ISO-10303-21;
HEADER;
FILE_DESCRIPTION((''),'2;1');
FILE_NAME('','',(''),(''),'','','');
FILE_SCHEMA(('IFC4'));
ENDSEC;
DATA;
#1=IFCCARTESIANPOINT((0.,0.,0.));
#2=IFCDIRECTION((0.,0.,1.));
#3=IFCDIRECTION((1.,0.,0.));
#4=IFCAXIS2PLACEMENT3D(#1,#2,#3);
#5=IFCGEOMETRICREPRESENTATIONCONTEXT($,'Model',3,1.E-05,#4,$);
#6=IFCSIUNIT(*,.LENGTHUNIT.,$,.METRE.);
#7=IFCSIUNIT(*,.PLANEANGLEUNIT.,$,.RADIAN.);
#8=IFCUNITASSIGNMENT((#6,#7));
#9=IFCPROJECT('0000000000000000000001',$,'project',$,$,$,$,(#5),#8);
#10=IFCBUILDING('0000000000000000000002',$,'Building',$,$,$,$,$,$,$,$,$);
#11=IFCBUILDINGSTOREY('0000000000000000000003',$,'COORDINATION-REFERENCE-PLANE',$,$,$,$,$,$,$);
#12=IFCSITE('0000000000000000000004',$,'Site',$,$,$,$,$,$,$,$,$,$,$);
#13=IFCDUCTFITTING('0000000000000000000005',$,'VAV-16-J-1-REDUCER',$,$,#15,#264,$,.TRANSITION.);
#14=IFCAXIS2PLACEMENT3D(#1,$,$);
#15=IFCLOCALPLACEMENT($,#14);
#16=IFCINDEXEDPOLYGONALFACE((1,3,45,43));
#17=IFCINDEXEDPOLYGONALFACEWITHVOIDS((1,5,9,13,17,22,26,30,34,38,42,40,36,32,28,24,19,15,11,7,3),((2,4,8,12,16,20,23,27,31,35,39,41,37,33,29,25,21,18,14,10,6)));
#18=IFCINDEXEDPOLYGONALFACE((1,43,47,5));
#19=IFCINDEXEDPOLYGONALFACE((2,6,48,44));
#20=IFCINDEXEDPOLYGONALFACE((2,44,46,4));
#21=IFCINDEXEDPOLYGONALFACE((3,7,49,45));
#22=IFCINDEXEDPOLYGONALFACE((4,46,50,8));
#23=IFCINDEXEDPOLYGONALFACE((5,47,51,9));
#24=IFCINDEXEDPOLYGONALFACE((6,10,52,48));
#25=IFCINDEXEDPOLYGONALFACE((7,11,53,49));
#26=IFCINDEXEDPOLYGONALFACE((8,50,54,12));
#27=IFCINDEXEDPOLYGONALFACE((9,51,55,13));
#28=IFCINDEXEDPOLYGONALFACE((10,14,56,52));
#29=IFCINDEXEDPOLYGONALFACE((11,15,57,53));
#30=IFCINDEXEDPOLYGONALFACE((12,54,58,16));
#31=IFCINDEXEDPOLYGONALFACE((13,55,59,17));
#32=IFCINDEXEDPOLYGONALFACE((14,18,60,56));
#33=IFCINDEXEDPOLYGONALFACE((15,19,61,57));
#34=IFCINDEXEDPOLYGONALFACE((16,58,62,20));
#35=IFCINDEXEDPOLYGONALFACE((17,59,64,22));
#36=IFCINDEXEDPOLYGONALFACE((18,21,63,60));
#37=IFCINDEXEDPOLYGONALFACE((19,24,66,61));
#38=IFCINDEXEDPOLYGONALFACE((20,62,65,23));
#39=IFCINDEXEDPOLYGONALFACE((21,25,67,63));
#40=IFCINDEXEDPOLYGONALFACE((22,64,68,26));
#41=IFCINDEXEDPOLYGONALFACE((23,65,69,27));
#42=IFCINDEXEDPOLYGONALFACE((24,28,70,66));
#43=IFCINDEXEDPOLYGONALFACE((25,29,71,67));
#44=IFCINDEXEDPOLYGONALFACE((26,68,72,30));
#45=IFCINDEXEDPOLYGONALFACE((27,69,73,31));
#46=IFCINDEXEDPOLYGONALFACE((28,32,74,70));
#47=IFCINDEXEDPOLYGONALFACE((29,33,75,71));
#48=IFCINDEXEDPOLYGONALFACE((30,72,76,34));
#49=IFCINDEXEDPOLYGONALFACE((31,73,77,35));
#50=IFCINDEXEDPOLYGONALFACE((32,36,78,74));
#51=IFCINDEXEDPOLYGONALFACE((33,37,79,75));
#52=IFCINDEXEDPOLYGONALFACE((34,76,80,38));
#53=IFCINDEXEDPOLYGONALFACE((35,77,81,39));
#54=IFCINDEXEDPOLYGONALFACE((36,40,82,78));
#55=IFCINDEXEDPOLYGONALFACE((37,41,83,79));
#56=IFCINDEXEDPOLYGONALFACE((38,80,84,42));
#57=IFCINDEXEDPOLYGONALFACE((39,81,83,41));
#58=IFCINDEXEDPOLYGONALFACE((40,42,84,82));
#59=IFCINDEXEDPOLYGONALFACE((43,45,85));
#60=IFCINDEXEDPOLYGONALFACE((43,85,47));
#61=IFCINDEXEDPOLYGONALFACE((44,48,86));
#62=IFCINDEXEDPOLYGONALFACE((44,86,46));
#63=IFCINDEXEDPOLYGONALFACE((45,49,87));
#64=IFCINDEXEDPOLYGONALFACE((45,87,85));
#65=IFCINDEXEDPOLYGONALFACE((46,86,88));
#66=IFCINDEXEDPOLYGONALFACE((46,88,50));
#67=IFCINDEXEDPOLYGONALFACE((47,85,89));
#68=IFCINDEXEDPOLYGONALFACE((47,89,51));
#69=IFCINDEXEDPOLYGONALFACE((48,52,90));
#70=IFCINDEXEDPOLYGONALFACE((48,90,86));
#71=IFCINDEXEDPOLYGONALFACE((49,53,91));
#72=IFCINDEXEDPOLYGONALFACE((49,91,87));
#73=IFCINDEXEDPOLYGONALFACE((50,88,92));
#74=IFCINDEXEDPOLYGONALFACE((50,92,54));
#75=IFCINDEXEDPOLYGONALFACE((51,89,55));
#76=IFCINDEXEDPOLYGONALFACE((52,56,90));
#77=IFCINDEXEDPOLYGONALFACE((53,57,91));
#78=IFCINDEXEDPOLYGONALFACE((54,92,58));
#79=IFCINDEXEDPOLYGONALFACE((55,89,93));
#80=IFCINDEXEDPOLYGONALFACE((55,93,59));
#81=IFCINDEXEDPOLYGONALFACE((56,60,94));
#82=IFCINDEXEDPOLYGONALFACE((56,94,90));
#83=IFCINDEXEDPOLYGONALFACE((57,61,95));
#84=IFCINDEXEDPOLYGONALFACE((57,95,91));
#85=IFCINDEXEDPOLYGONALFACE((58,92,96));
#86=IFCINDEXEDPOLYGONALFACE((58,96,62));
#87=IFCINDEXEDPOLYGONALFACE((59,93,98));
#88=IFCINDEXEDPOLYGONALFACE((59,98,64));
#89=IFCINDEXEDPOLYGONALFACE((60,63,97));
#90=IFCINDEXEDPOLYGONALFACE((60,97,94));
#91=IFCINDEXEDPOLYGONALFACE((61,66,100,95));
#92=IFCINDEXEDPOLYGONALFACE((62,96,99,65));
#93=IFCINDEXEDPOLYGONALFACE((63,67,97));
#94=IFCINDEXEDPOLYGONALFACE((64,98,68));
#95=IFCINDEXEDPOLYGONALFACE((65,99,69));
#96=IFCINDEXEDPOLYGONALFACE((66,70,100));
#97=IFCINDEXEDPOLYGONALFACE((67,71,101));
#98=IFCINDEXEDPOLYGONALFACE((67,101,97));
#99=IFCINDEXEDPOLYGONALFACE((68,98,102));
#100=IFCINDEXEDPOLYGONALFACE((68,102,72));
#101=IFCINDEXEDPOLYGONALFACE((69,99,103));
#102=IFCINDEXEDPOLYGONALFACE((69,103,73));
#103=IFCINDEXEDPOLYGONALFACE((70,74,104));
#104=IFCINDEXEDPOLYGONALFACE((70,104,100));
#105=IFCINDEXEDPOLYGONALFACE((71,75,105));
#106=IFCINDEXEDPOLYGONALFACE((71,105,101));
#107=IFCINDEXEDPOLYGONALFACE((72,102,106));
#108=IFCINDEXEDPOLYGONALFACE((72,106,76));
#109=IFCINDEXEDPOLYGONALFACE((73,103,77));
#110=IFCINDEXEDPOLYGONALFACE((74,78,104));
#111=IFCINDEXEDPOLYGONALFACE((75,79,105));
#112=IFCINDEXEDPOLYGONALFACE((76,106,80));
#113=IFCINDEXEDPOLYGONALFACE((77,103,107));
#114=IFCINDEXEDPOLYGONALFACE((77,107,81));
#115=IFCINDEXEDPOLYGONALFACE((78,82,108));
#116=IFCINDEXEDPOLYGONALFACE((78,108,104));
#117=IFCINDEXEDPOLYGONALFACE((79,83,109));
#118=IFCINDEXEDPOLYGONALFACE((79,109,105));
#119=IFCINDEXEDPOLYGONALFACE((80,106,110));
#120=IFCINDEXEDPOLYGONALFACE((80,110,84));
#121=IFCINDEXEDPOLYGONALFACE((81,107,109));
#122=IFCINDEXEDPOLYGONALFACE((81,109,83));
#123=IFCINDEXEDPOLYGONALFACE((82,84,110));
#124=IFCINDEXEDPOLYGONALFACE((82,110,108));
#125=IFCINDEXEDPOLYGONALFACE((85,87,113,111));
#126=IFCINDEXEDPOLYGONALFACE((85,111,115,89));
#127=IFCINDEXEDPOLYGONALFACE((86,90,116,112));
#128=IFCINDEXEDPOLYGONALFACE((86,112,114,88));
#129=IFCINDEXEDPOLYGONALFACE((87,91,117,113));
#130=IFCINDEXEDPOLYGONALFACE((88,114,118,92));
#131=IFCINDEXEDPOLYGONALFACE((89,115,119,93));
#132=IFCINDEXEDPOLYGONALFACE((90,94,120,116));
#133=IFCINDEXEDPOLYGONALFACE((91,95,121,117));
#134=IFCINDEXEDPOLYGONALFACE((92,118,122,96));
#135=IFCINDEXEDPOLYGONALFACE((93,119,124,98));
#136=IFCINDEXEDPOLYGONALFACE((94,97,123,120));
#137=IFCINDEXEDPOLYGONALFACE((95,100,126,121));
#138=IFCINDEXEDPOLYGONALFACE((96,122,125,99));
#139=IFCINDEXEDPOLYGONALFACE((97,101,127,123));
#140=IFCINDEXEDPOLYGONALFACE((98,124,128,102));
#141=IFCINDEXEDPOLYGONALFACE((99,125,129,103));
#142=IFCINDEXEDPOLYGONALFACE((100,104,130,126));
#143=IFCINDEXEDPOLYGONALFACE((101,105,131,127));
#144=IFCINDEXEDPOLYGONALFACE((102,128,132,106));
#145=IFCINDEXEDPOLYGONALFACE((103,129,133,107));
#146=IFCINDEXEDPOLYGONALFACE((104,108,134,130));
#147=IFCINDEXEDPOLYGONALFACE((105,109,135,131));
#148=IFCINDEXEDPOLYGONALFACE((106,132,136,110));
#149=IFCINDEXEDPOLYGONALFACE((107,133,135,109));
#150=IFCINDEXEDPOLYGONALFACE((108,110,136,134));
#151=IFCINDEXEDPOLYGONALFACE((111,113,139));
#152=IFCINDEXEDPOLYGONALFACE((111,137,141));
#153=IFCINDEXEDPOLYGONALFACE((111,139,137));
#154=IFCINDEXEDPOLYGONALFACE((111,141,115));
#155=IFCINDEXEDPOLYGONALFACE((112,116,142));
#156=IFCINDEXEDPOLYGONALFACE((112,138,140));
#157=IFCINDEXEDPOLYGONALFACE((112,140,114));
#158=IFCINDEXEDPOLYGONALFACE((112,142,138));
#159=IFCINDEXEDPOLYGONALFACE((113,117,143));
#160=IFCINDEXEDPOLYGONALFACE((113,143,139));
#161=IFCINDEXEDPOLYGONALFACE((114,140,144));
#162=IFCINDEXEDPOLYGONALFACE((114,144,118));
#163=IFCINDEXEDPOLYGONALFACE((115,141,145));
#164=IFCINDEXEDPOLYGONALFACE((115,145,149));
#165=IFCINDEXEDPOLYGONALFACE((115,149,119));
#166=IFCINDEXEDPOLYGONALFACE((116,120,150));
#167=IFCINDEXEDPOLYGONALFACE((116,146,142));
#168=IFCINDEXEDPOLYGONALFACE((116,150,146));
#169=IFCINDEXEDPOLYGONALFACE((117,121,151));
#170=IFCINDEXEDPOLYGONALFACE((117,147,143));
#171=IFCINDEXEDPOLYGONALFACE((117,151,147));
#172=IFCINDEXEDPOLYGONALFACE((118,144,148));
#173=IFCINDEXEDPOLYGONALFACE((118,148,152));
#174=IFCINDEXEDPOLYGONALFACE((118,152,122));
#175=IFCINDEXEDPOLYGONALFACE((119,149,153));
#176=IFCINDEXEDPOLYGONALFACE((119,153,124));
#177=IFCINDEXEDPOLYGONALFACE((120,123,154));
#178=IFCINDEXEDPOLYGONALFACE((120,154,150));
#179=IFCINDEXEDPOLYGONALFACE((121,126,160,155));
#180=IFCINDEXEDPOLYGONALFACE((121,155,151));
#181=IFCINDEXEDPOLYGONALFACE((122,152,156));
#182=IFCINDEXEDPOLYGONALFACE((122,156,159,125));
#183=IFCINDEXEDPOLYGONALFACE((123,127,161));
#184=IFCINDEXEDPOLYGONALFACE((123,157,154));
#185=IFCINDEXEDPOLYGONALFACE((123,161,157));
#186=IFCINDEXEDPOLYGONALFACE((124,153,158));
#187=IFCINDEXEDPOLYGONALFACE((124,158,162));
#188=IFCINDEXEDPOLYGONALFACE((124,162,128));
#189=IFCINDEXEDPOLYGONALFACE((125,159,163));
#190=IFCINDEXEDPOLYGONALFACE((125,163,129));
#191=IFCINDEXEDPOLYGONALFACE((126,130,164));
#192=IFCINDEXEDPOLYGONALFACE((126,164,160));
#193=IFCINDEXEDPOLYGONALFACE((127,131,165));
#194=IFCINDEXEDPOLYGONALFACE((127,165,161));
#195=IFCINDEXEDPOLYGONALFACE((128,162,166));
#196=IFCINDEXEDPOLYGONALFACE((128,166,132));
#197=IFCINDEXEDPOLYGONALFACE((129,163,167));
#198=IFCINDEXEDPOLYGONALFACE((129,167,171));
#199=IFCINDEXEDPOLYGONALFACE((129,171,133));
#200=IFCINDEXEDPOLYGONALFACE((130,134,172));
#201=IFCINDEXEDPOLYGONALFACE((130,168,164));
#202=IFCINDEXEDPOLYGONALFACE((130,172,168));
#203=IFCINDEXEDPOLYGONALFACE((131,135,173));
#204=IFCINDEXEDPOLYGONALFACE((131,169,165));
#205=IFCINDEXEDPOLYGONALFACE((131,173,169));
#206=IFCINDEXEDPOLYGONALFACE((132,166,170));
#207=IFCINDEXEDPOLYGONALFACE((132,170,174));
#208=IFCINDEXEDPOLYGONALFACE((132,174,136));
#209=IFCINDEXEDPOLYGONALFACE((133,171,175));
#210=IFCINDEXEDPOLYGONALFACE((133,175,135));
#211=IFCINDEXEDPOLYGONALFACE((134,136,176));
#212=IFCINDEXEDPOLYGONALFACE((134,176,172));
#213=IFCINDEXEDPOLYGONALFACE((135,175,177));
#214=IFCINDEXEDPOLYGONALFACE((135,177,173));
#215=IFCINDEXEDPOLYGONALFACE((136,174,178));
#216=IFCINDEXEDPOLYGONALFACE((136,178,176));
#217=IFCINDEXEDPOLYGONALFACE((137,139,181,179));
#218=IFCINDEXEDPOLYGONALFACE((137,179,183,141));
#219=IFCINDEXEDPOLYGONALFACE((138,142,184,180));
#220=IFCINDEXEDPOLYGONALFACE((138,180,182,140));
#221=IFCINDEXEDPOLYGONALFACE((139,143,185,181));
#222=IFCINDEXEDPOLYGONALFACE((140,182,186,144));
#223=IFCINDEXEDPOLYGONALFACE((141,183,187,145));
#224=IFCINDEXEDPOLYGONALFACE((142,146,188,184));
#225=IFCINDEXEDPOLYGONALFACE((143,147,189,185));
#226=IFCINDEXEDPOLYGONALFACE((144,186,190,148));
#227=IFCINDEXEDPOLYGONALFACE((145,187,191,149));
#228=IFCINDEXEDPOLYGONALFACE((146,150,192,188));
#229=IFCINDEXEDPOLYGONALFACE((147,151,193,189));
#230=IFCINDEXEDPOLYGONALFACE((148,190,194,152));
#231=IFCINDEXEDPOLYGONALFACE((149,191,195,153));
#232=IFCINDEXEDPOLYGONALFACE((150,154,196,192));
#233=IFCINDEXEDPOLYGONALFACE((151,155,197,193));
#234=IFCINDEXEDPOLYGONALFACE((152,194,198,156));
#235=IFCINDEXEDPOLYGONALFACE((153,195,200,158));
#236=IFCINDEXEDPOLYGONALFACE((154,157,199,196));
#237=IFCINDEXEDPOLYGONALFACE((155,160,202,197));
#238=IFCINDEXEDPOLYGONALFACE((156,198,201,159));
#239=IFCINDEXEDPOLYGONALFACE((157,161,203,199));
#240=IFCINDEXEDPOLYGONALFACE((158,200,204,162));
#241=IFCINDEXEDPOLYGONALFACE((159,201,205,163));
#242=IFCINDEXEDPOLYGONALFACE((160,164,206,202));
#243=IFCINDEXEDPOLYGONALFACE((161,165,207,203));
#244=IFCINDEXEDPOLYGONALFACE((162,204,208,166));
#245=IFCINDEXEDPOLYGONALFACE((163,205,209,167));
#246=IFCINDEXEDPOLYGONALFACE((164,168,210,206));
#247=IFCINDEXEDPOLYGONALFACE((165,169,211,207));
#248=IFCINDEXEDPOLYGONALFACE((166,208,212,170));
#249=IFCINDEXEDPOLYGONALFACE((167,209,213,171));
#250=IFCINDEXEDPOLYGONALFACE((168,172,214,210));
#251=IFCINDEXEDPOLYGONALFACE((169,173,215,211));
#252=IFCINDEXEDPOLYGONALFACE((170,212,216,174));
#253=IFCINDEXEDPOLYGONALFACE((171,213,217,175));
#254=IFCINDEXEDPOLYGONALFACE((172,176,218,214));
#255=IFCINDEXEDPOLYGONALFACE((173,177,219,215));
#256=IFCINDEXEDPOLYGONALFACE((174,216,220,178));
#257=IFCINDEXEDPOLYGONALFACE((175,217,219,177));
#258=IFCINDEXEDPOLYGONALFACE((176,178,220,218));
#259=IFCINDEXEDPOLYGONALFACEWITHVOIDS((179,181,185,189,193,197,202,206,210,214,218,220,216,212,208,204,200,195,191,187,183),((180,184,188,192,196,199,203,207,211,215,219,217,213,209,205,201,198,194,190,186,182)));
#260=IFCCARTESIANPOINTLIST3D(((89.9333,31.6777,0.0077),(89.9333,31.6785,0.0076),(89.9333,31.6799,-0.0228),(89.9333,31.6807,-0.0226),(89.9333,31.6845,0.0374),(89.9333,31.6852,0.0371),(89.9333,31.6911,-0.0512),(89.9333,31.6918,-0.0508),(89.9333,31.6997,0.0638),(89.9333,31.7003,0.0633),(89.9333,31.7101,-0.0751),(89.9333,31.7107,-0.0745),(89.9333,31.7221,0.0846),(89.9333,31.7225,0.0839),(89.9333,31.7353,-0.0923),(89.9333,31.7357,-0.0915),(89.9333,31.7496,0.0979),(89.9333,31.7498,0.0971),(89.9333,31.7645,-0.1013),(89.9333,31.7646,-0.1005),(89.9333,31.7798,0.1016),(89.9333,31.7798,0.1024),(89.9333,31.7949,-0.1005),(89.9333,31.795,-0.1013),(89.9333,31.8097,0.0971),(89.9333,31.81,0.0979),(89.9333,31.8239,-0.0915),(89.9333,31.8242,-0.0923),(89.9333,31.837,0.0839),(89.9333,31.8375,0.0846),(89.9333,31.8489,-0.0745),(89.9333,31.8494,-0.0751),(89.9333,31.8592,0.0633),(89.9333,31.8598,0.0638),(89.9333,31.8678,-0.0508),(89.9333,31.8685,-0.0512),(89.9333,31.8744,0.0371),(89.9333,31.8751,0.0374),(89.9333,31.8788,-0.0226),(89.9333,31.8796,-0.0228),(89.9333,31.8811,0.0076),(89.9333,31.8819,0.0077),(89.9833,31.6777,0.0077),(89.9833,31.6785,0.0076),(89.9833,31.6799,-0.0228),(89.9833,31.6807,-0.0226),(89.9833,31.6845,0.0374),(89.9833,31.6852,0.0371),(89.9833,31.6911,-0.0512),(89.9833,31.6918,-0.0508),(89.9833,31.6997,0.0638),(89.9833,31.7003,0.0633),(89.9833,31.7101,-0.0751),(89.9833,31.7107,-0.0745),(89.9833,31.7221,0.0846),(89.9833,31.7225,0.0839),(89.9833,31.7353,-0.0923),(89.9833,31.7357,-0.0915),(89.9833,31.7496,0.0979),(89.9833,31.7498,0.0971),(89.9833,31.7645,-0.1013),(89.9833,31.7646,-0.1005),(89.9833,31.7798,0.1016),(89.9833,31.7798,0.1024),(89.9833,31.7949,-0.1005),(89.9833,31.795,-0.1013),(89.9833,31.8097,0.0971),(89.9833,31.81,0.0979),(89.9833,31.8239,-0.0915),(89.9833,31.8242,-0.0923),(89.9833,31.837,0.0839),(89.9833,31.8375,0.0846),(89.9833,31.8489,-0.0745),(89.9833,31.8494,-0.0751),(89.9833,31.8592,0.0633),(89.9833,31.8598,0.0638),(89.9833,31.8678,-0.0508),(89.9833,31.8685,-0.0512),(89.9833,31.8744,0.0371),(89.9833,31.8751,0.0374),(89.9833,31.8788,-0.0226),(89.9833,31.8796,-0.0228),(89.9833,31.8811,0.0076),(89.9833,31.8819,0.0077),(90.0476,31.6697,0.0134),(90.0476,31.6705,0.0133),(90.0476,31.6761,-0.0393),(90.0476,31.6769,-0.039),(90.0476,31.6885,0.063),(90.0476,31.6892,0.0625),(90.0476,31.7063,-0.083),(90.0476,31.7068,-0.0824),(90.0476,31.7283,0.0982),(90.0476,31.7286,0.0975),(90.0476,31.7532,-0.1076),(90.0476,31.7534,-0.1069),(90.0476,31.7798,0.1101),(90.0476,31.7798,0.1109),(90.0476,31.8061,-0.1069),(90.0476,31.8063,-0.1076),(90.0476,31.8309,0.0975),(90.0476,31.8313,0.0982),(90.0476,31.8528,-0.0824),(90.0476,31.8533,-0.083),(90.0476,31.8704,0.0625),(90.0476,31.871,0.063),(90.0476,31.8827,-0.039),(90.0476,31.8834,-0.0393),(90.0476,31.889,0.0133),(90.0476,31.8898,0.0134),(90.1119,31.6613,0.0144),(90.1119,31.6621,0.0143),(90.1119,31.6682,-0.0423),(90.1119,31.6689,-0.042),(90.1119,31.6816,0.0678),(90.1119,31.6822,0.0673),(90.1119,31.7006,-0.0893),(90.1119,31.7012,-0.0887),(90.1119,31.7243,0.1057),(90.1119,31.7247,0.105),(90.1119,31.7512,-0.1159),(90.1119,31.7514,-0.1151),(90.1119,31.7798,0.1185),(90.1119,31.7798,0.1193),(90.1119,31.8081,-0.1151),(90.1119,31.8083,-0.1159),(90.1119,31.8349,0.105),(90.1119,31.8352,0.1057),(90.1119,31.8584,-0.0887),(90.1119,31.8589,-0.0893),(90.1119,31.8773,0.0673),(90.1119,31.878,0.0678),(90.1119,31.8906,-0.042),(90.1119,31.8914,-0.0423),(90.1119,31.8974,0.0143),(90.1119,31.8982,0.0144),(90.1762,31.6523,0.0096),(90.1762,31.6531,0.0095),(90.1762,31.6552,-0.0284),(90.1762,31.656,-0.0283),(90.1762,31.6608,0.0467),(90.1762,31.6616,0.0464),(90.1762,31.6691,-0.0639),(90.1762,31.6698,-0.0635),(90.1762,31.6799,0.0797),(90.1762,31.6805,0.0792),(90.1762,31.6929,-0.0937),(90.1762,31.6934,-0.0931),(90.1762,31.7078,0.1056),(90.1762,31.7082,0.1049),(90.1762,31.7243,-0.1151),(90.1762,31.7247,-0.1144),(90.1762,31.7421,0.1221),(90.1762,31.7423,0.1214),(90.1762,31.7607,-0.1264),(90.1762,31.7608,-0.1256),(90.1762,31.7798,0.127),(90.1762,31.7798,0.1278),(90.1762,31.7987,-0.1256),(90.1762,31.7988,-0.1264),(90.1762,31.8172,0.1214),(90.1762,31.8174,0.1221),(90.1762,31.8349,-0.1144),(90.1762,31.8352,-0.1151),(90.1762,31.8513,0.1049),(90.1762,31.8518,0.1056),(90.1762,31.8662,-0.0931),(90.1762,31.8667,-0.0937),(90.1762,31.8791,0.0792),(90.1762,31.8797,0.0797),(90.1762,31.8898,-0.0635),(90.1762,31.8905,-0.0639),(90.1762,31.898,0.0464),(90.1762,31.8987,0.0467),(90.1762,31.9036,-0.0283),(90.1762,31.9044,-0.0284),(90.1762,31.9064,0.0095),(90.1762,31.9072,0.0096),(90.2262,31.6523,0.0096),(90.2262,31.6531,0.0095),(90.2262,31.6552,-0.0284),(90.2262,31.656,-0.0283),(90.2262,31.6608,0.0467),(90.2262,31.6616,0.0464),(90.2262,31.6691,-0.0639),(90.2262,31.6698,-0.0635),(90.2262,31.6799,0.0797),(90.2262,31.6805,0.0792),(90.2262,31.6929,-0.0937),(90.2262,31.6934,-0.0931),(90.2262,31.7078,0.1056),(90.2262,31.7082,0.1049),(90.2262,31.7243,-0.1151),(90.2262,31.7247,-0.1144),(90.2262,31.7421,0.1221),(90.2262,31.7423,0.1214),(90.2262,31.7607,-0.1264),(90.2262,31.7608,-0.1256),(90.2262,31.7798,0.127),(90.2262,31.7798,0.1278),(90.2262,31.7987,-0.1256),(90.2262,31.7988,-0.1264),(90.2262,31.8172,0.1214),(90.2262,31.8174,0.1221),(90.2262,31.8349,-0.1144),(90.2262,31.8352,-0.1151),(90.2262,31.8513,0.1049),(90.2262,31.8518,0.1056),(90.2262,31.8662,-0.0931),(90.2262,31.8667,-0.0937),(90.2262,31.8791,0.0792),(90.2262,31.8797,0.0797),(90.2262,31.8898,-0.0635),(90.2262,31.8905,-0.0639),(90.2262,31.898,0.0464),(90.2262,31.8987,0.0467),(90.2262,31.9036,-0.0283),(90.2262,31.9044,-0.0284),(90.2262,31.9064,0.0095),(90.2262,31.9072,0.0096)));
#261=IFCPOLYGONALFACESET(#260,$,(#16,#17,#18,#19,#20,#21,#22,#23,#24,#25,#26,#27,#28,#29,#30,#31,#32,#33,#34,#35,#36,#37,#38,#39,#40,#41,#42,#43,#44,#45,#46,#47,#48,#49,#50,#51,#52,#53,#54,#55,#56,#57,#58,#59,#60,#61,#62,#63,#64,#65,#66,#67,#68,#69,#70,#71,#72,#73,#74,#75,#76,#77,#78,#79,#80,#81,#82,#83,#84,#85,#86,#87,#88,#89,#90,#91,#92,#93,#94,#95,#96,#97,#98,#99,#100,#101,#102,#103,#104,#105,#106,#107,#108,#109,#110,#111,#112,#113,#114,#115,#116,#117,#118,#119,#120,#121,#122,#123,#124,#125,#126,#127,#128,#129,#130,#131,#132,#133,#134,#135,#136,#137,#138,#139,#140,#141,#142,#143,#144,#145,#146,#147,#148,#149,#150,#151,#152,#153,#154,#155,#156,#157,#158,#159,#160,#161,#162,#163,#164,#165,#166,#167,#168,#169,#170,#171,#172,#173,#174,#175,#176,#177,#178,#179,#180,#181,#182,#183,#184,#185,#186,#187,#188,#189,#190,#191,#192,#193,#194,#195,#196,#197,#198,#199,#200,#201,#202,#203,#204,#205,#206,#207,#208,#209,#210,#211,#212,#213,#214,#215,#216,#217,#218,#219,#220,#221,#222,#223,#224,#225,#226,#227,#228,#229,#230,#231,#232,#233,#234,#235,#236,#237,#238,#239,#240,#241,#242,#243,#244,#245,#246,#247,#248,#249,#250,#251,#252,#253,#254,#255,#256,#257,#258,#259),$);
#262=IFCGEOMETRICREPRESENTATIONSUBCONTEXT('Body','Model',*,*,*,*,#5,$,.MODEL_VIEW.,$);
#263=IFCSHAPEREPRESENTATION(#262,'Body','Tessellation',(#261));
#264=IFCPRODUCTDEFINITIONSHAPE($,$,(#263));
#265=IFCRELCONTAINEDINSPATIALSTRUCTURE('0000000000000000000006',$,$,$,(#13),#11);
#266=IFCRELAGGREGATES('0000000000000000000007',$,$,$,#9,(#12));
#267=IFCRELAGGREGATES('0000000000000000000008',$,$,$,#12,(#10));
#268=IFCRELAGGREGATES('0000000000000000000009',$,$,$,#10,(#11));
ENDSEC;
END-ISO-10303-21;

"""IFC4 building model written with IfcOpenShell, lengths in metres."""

from ifc_helpers import new_model, entity, si_unit, frame, origin_with_axes, place, context, subcontext, project, spatial, element, save


model = new_model("IFC4")

# Units and contexts
model_context = context("Model", 3, precision=1e-05, world=origin_with_axes())
body_context_1 = subcontext(model_context, "Body", "Model", "MODEL_VIEW")
ifc_project = project(units=[si_unit("LENGTHUNIT", "METRE"), si_unit("PLANEANGLEUNIT", "RADIAN")], contexts=[model_context])

# Site, building, storey
site = spatial("IfcSite", under=ifc_project, Name="Site")
building = spatial("IfcBuilding", under=site, Name="Building")
storey = spatial("IfcBuildingStorey", under=building, Name="COORDINATION-REFERENCE-PLANE")

# Duct fitting
for number, where, z_axis, x_axis, name in (
    (1, (90.2262, 31.7798, 0.0), (0.0, -1.0, 0.0), (0.0, 0.0, 1.0), "VAV-16-J-1-REDUCER"),
):
    element("IfcDuctFitting", number, at=place(None, frame(where, z_axis=z_axis, x_axis=x_axis)), inside=storey, Name=name, PredefinedType="TRANSITION", context=body_context_1, shape_type="SweptSolid", body=[
        entity("IfcRevolvedAreaSolid", entity("IfcArbitraryClosedProfileDef", "AREA", None, entity("IfcPolyline", [entity("IfcCartesianPoint", [0.1278, 0.0]), entity("IfcCartesianPoint", [0.1278, 0.05]), entity("IfcCartesianPoint", [0.1024, 0.2429]), entity("IfcCartesianPoint", [0.1024, 0.2929]), entity("IfcCartesianPoint", [0.1016, 0.2929]), entity("IfcCartesianPoint", [0.1016, 0.2429]), entity("IfcCartesianPoint", [0.127, 0.05]), entity("IfcCartesianPoint", [0.127, 0.0]), entity("IfcCartesianPoint", [0.1278, 0.0])])), entity("IfcAxis2Placement3D", entity("IfcCartesianPoint", [0.0, 0.0, 0.0])), entity("IfcAxis1Placement", entity("IfcCartesianPoint", [0.0, 0.0, 0.0]), entity("IfcDirection", [0.0, 1.0, 0.0])), 6.283185),
    ])

save(model, "model.ifc")
